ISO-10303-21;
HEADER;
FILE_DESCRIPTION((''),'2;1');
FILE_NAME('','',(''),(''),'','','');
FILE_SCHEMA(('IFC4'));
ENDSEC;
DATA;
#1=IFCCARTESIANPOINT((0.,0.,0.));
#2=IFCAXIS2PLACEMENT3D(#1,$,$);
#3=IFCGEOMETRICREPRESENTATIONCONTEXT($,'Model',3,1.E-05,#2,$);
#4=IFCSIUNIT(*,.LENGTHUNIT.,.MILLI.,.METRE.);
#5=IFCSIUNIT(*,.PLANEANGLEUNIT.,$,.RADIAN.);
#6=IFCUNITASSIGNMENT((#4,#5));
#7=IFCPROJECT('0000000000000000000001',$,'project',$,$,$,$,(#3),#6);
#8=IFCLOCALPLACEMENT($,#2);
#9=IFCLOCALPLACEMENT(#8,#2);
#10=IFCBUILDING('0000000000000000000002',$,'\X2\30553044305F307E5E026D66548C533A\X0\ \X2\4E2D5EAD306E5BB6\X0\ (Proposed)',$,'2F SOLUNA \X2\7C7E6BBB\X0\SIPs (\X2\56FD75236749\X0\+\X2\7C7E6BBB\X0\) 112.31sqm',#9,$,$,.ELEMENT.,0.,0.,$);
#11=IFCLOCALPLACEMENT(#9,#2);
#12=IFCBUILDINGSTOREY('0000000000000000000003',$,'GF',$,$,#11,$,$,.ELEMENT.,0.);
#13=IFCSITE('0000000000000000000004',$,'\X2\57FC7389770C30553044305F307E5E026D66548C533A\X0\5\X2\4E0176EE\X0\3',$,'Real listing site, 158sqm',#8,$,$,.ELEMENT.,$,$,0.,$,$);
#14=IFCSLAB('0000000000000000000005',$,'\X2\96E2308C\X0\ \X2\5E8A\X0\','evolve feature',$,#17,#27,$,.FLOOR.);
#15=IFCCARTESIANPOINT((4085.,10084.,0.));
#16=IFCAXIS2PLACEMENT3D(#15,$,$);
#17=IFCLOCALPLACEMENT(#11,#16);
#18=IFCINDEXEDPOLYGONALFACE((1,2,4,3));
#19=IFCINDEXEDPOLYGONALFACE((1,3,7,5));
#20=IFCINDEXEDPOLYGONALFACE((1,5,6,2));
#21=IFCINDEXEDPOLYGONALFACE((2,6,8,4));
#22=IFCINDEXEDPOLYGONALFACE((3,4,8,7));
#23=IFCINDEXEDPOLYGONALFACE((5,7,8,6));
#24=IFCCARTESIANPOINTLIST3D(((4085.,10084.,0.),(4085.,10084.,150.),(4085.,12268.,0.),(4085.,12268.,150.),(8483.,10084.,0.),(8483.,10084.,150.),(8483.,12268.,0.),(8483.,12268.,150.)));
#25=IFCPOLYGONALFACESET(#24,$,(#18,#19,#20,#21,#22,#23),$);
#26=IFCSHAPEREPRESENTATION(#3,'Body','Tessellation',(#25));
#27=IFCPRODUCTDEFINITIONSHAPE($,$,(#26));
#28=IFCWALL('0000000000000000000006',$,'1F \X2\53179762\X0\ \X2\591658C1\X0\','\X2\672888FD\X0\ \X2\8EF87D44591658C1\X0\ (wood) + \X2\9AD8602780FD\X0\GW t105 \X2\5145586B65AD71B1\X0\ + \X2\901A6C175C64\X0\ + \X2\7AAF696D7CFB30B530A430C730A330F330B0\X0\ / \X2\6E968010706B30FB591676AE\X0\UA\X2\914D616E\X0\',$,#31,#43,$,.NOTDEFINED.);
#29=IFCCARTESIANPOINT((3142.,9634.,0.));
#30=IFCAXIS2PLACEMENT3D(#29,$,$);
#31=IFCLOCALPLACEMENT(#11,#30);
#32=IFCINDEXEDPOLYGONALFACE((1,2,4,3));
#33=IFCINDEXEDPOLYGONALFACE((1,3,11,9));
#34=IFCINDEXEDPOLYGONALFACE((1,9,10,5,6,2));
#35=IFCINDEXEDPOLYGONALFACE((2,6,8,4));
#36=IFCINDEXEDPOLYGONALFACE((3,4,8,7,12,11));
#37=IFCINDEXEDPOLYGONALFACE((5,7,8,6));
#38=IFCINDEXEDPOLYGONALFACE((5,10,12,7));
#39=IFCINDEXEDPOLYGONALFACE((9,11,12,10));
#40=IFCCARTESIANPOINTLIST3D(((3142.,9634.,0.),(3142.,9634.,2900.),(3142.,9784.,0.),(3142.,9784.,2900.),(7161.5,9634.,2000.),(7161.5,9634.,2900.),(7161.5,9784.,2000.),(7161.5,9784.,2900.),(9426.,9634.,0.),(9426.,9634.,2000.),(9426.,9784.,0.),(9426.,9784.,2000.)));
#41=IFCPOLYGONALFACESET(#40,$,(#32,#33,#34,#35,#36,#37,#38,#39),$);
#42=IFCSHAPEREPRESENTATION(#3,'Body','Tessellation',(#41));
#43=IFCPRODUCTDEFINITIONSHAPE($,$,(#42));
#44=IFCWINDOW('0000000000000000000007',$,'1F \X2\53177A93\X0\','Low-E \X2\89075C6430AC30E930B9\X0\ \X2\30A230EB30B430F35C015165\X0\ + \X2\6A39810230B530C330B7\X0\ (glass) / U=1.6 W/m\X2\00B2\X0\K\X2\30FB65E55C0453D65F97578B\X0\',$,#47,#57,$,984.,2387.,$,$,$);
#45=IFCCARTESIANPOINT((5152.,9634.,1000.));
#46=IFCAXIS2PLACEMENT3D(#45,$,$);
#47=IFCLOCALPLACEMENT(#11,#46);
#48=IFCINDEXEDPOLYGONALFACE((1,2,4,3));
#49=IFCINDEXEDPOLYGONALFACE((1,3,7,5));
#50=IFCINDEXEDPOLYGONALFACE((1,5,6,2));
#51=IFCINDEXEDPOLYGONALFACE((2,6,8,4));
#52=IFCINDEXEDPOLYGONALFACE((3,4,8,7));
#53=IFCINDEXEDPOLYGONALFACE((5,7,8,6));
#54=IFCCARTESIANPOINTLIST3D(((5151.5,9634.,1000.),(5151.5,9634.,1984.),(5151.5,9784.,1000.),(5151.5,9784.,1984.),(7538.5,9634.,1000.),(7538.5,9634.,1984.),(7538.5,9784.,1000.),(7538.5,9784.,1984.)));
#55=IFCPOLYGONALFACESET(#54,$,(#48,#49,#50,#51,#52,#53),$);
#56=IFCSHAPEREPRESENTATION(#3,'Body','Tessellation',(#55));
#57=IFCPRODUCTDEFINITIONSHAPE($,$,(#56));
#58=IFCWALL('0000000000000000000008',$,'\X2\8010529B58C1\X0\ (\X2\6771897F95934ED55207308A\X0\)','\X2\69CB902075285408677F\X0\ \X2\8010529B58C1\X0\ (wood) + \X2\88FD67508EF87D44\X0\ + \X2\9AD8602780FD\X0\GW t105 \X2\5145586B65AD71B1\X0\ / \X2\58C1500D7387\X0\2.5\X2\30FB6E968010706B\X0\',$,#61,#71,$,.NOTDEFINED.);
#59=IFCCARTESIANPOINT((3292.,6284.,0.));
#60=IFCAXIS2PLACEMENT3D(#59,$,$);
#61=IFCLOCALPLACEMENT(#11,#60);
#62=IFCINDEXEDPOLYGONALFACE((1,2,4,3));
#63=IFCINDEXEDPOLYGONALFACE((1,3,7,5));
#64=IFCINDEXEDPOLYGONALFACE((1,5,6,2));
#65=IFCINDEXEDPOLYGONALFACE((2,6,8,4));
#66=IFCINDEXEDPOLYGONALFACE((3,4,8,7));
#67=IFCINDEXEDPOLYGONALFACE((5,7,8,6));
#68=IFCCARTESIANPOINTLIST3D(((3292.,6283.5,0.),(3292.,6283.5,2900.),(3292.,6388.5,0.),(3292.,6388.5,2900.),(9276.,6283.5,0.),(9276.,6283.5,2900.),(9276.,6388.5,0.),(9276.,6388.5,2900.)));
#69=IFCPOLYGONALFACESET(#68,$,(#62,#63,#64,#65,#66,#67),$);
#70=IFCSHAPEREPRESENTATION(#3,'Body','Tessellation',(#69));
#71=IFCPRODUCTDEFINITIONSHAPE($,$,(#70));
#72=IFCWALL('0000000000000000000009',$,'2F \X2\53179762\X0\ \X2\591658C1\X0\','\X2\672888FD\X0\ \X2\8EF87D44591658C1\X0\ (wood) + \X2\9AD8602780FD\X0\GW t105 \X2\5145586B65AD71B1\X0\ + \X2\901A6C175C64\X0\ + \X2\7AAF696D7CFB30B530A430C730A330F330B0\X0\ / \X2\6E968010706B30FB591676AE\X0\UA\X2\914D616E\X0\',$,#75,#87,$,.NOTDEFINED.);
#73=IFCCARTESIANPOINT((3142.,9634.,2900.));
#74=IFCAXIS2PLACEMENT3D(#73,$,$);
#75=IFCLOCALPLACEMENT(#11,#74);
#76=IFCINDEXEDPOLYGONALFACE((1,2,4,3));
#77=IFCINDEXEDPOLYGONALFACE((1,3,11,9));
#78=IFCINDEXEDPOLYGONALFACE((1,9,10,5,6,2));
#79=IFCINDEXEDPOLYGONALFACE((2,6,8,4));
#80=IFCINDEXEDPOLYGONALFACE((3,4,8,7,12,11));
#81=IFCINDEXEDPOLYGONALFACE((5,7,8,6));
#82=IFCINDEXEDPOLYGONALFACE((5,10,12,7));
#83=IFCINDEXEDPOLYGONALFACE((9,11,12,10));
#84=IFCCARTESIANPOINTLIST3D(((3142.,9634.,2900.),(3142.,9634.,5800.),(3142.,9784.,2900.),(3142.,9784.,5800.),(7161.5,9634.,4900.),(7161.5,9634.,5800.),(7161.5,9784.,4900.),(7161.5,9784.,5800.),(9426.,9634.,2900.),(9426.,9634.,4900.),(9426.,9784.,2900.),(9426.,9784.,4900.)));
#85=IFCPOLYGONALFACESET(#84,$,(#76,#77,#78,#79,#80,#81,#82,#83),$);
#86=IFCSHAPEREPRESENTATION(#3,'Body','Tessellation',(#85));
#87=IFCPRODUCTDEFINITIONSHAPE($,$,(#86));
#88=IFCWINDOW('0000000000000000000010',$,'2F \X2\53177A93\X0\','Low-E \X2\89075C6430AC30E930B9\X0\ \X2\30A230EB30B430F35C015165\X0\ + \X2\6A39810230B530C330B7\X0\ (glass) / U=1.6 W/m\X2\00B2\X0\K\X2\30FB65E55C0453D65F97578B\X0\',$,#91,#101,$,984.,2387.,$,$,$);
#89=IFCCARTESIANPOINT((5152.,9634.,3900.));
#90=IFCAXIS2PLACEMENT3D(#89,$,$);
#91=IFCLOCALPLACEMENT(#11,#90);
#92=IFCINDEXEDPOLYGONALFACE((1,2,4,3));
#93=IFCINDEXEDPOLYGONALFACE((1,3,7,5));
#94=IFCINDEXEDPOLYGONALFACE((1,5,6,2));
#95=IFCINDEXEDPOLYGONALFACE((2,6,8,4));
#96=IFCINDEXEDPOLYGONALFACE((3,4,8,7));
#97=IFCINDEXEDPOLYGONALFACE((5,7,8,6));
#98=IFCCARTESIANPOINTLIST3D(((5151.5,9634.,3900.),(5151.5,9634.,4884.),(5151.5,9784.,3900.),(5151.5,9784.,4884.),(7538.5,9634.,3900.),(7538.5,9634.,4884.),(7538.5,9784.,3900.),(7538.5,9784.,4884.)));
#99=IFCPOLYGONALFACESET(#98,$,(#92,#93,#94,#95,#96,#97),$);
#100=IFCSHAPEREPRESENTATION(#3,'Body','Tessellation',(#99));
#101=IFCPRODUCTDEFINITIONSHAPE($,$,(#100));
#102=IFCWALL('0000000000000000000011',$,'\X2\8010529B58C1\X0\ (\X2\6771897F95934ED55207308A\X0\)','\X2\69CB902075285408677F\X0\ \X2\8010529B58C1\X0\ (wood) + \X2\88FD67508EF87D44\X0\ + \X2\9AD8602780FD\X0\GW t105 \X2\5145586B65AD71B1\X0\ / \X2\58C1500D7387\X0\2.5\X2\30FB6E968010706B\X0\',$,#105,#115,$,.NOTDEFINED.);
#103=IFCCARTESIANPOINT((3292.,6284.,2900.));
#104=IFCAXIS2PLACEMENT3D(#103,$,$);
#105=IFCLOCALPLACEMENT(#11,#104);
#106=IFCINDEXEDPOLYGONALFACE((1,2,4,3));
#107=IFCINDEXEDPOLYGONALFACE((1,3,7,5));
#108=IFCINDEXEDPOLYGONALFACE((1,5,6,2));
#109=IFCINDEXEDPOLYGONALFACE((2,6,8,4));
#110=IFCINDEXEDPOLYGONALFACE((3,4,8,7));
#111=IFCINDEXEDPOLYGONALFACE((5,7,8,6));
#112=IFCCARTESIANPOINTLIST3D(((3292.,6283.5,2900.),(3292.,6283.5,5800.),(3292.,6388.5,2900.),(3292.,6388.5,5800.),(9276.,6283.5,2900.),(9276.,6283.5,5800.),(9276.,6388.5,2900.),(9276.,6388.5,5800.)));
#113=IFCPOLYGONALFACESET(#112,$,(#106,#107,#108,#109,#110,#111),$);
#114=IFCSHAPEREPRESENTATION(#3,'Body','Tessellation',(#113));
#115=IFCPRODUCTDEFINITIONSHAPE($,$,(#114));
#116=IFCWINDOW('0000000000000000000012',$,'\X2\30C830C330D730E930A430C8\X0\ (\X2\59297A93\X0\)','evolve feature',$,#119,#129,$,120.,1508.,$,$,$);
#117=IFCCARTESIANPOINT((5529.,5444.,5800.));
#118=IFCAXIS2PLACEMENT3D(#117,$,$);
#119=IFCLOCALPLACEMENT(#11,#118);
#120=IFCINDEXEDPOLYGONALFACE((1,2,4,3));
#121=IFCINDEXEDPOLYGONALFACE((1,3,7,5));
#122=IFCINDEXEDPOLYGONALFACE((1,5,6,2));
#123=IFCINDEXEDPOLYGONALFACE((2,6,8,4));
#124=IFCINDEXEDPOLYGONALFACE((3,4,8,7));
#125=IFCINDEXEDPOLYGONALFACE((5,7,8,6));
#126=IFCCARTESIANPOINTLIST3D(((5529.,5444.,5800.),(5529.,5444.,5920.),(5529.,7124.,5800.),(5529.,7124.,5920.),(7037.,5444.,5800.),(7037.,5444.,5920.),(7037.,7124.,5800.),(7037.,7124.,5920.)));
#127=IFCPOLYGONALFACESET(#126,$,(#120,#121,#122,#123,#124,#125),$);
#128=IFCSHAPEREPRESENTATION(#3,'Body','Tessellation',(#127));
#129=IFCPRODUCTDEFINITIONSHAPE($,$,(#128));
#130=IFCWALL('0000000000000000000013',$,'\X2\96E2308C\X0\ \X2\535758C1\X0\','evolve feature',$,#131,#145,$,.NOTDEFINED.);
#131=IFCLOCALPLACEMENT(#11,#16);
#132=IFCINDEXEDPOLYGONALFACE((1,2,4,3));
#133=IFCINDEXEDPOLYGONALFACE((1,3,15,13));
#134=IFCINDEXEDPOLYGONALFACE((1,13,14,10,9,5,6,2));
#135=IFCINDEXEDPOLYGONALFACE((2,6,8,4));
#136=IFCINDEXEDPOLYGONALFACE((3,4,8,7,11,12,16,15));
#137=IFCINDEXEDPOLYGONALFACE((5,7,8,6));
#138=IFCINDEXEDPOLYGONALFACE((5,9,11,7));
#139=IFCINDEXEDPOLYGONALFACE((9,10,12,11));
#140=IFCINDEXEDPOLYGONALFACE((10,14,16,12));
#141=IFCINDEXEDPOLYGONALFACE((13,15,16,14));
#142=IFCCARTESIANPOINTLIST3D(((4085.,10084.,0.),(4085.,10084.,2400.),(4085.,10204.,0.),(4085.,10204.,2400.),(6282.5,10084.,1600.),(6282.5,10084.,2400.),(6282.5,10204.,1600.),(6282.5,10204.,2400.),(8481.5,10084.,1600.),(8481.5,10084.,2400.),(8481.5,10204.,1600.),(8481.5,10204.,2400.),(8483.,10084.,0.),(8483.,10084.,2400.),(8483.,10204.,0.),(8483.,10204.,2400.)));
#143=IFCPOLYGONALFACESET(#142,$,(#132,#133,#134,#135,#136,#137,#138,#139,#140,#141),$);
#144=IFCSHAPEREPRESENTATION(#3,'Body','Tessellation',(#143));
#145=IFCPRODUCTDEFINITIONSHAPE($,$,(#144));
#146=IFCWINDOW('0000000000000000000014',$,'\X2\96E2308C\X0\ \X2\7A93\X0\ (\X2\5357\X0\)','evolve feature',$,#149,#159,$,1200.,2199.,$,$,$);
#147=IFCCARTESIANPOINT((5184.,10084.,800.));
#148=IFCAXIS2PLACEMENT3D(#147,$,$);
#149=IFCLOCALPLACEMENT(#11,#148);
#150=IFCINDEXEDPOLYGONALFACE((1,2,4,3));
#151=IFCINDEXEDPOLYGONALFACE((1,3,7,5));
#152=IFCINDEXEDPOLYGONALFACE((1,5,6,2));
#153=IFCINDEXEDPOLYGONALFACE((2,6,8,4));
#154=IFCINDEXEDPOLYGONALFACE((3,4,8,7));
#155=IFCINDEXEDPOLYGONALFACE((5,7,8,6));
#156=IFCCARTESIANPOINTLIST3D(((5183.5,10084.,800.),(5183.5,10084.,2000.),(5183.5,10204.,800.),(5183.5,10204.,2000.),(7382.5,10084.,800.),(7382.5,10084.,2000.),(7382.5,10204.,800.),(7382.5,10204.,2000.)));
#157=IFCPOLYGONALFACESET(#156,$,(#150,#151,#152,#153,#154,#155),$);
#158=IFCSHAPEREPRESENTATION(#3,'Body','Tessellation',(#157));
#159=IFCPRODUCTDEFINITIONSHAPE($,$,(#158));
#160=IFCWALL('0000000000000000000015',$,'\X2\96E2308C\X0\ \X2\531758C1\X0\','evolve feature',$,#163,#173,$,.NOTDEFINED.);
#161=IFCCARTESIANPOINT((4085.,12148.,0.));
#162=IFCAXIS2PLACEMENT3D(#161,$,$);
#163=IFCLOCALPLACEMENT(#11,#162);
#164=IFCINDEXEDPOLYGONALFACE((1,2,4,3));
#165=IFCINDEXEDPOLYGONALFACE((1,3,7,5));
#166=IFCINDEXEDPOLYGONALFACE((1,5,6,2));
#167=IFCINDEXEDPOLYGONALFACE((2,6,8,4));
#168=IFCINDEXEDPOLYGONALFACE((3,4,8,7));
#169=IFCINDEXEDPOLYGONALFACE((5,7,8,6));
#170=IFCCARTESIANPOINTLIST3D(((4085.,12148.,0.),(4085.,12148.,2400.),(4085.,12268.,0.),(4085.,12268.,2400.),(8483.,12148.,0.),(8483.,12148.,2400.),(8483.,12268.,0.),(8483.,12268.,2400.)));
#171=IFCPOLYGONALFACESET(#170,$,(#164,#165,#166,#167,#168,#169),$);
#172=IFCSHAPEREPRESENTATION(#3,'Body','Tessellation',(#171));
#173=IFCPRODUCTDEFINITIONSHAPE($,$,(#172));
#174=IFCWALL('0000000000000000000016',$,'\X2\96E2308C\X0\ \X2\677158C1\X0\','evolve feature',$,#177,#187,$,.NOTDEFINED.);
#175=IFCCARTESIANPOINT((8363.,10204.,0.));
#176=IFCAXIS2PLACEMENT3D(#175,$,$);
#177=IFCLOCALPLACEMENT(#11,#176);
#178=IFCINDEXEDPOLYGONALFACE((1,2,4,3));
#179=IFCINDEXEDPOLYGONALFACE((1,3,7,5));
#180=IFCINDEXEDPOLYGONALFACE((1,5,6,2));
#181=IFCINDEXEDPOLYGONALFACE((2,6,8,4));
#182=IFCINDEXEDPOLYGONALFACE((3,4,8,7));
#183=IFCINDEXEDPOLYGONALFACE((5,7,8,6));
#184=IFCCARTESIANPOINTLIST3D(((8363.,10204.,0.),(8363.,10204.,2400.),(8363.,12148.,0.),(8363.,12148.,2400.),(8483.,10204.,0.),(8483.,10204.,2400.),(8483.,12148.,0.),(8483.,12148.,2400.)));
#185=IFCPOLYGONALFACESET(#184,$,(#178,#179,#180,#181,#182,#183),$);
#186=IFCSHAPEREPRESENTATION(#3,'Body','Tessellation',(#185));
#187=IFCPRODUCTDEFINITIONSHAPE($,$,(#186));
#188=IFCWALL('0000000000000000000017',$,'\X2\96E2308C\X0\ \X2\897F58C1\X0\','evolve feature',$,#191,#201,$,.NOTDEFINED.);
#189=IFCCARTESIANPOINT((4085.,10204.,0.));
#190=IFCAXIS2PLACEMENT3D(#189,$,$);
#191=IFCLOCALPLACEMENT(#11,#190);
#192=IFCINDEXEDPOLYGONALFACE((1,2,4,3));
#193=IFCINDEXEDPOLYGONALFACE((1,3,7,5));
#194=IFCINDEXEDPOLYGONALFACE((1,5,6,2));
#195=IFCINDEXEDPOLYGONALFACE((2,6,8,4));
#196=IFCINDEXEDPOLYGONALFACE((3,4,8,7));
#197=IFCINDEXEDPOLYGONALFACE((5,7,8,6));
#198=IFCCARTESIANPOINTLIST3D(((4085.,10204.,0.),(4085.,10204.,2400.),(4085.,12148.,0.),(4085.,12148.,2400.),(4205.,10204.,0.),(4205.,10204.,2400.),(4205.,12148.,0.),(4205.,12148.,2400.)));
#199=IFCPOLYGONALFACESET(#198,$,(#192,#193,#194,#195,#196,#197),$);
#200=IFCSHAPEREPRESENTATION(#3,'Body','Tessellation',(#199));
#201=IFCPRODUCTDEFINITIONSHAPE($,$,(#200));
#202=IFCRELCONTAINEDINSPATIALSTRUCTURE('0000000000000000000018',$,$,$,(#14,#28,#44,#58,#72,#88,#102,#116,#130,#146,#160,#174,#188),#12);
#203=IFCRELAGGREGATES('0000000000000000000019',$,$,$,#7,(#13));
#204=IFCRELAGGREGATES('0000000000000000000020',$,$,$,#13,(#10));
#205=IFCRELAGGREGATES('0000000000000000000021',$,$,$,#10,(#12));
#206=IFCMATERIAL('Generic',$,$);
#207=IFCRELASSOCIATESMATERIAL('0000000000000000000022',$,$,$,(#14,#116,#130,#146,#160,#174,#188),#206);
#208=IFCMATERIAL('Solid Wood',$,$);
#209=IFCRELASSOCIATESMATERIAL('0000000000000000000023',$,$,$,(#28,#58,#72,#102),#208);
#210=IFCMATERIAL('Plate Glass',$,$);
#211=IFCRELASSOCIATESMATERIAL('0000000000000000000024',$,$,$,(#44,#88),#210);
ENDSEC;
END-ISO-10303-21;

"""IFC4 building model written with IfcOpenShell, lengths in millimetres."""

from ifc_helpers import new_model, si_unit, frame, frame_2d, origin, place, context, project, spatial, rectangle, extrude, material, element, fill, save


model = new_model("IFC4")

# Units and contexts
model_context = context("Model", 3, precision=1e-05, world=origin())
ifc_project = project(units=[si_unit("LENGTHUNIT", "METRE", prefix="MILLI"), si_unit("PLANEANGLEUNIT", "RADIAN")], contexts=[model_context])

# Site, building, storey
site_placement = place(None, origin())
site = spatial("IfcSite", under=ifc_project, at=site_placement, Name="埼玉県さいたま市浦和区5丁目3", ObjectType="Real listing site, 158sqm", CompositionType="ELEMENT", RefElevation=0.0)
building_placement = place(site_placement, origin())
building = spatial("IfcBuilding", under=site, at=building_placement, Name="さいたま市浦和区 中庭の家 (Proposed)", ObjectType="2F SOLUNA 籾殻SIPs (国産杉+籾殻) 112.31sqm", CompositionType="ELEMENT", ElevationOfRefHeight=0.0, ElevationOfTerrain=0.0)
storey_placement = place(building_placement, origin())
storey = spatial("IfcBuildingStorey", under=building, at=storey_placement, Name="GF", CompositionType="ELEMENT", Elevation=0.0)

# Slab
ifc_material_1 = material(Name="Generic")
slab_placement = place(storey_placement, frame((4085.0, 10084.0, 0.0)))
element("IfcSlab", 1, at=slab_placement, inside=storey, material=ifc_material_1, Name="離れ 床", Description="evolve feature", PredefinedType="FLOOR", context=model_context, shape_type="SweptSolid", body=[
    extrude(rectangle(XDim=4398.0, YDim=2184.0, at=frame_2d((2199.0, 1092.0))), frame((4085.0, 10084.0, 0.0)), (0.0, 0.0, 1.0), 150.0),
])

# Wall, opening, window
ifc_material_2 = material(Name="Solid Wood")
wall_1_placement = place(storey_placement, frame((3142.0, 9634.0, 0.0)))
wall_1 = element("IfcWall", 2, at=wall_1_placement, inside=storey, material=ifc_material_2, Name="1F 北面 外壁", Description="木製 軸組外壁 (wood) + 高性能GW t105 充填断熱 + 通気層 + 窯業系サイディング / 準耐火・外皮UA配慮", PredefinedType="NOTDEFINED", context=model_context, shape_type="SweptSolid", body=[
    extrude(rectangle(XDim=6284.0, YDim=150.0, at=frame_2d((3142.0, 75.0))), frame((3142.0, 9634.0, 0.0)), (0.0, 0.0, 1.0), 2900.0),
])
opening_1_placement = place(storey_placement, frame((5152.0, 9634.0, 1000.0)))
opening_1 = element("IfcOpeningElement", 3, at=opening_1_placement, cuts=wall_1, PredefinedType="NOTDEFINED", context=model_context, shape_type="SweptSolid", body=[
    extrude(rectangle(XDim=2387.0, YDim=150.0, at=frame_2d((1193.0, 75.0))), frame((5152.0, 9634.0, 1000.0)), (0.0, 0.0, 1.0), 984.0),
])
ifc_material_3 = material(Name="Plate Glass")
window_1_placement = place(storey_placement, frame((5152.0, 9634.0, 1000.0)))
window_1 = element("IfcWindow", 4, at=window_1_placement, inside=storey, material=ifc_material_3, Name="1F 北窓", Description="Low-E 複層ガラス アルゴン封入 + 樹脂サッシ (glass) / U=1.6 W/m²K・日射取得型", OverallHeight=984.0, OverallWidth=2387.0, context=model_context, shape_type="SweptSolid", body=[
    extrude(rectangle(XDim=2387.0, YDim=150.0, at=frame_2d((1193.0, 75.0))), frame((5152.0, 9634.0, 1000.0)), (0.0, 0.0, 1.0), 984.0),
])
fill(opening_1, window_1)

# Wall
wall_2_placement = place(storey_placement, frame((3292.0, 6284.0, 0.0)))
element("IfcWall", 5, at=wall_2_placement, inside=storey, material=ifc_material_2, Name="耐力壁 (東西間仕切り)", Description="構造用合板 耐力壁 (wood) + 製材軸組 + 高性能GW t105 充填断熱 / 壁倍率2.5・準耐火", PredefinedType="NOTDEFINED", context=model_context, shape_type="SweptSolid", body=[
    extrude(rectangle(XDim=5984.0, YDim=105.0, at=frame_2d((2992.0, 52.0))), frame((3292.0, 6284.0, 0.0)), (0.0, 0.0, 1.0), 2900.0),
])

# Wall, opening, window
wall_3_placement = place(storey_placement, frame((3142.0, 9634.0, 2900.0)))
wall_3 = element("IfcWall", 6, at=wall_3_placement, inside=storey, material=ifc_material_2, Name="2F 北面 外壁", Description="木製 軸組外壁 (wood) + 高性能GW t105 充填断熱 + 通気層 + 窯業系サイディング / 準耐火・外皮UA配慮", PredefinedType="NOTDEFINED", context=model_context, shape_type="SweptSolid", body=[
    extrude(rectangle(XDim=6284.0, YDim=150.0, at=frame_2d((3142.0, 75.0))), frame((3142.0, 9634.0, 2900.0)), (0.0, 0.0, 1.0), 2900.0),
])
opening_2_placement = place(storey_placement, frame((5152.0, 9634.0, 3900.0)))
opening_2 = element("IfcOpeningElement", 7, at=opening_2_placement, cuts=wall_3, PredefinedType="NOTDEFINED", context=model_context, shape_type="SweptSolid", body=[
    extrude(rectangle(XDim=2387.0, YDim=150.0, at=frame_2d((1193.0, 75.0))), frame((5152.0, 9634.0, 3900.0)), (0.0, 0.0, 1.0), 984.0),
])
window_2_placement = place(storey_placement, frame((5152.0, 9634.0, 3900.0)))
window_2 = element("IfcWindow", 8, at=window_2_placement, inside=storey, material=ifc_material_3, Name="2F 北窓", Description="Low-E 複層ガラス アルゴン封入 + 樹脂サッシ (glass) / U=1.6 W/m²K・日射取得型", OverallHeight=984.0, OverallWidth=2387.0, context=model_context, shape_type="SweptSolid", body=[
    extrude(rectangle(XDim=2387.0, YDim=150.0, at=frame_2d((1193.0, 75.0))), frame((5152.0, 9634.0, 3900.0)), (0.0, 0.0, 1.0), 984.0),
])
fill(opening_2, window_2)

# Wall
wall_4_placement = place(storey_placement, frame((3292.0, 6284.0, 2900.0)))
element("IfcWall", 9, at=wall_4_placement, inside=storey, material=ifc_material_2, Name="耐力壁 (東西間仕切り)", Description="構造用合板 耐力壁 (wood) + 製材軸組 + 高性能GW t105 充填断熱 / 壁倍率2.5・準耐火", PredefinedType="NOTDEFINED", context=model_context, shape_type="SweptSolid", body=[
    extrude(rectangle(XDim=5984.0, YDim=105.0, at=frame_2d((2992.0, 52.0))), frame((3292.0, 6284.0, 2900.0)), (0.0, 0.0, 1.0), 2900.0),
])

# Window
window_3_placement = place(storey_placement, frame((5529.0, 5444.0, 5800.0)))
element("IfcWindow", 10, at=window_3_placement, inside=storey, material=ifc_material_1, Name="トップライト (天窓)", Description="evolve feature", OverallHeight=120.0, OverallWidth=1508.0, context=model_context, shape_type="SweptSolid", body=[
    extrude(rectangle(XDim=1508.0, YDim=1680.0, at=frame_2d((754.0, 840.0))), frame((5529.0, 5444.0, 5800.0)), (0.0, 0.0, 1.0), 120.0),
])

# Wall, opening, window
wall_5_placement = place(storey_placement, frame((4085.0, 10084.0, 0.0)))
wall_5 = element("IfcWall", 11, at=wall_5_placement, inside=storey, material=ifc_material_1, Name="離れ 南壁", Description="evolve feature", PredefinedType="NOTDEFINED", context=model_context, shape_type="SweptSolid", body=[
    extrude(rectangle(XDim=4398.0, YDim=120.0, at=frame_2d((2199.0, 60.0))), frame((4085.0, 10084.0, 0.0)), (0.0, 0.0, 1.0), 2400.0),
])
opening_3_placement = place(storey_placement, frame((5184.0, 10084.0, 800.0)))
opening_3 = element("IfcOpeningElement", 12, at=opening_3_placement, cuts=wall_5, PredefinedType="NOTDEFINED", context=model_context, shape_type="SweptSolid", body=[
    extrude(rectangle(XDim=2199.0, YDim=120.0, at=frame_2d((1099.0, 60.0))), frame((5184.0, 10084.0, 800.0)), (0.0, 0.0, 1.0), 1200.0),
])
window_4_placement = place(storey_placement, frame((5184.0, 10084.0, 800.0)))
window_4 = element("IfcWindow", 13, at=window_4_placement, inside=storey, material=ifc_material_1, Name="離れ 窓 (南)", Description="evolve feature", OverallHeight=1200.0, OverallWidth=2199.0, context=model_context, shape_type="SweptSolid", body=[
    extrude(rectangle(XDim=2199.0, YDim=120.0, at=frame_2d((1099.0, 60.0))), frame((5184.0, 10084.0, 800.0)), (0.0, 0.0, 1.0), 1200.0),
])
fill(opening_3, window_4)

# Walls
wall_6_placement = place(storey_placement, frame((4085.0, 12148.0, 0.0)))
element("IfcWall", 14, at=wall_6_placement, inside=storey, material=ifc_material_1, Name="離れ 北壁", Description="evolve feature", PredefinedType="NOTDEFINED", context=model_context, shape_type="SweptSolid", body=[
    extrude(rectangle(XDim=4398.0, YDim=120.0, at=frame_2d((2199.0, 60.0))), frame((4085.0, 12148.0, 0.0)), (0.0, 0.0, 1.0), 2400.0),
])
wall_7_placement = place(storey_placement, frame((8363.0, 10204.0, 0.0)))
element("IfcWall", 15, at=wall_7_placement, inside=storey, material=ifc_material_1, Name="離れ 東壁", Description="evolve feature", PredefinedType="NOTDEFINED", context=model_context, shape_type="SweptSolid", body=[
    extrude(rectangle(XDim=120.0, YDim=1944.0, at=frame_2d((60.0, 972.0))), frame((8363.0, 10204.0, 0.0)), (0.0, 0.0, 1.0), 2400.0),
])
wall_8_placement = place(storey_placement, frame((4085.0, 10204.0, 0.0)))
element("IfcWall", 16, at=wall_8_placement, inside=storey, material=ifc_material_1, Name="離れ 西壁", Description="evolve feature", PredefinedType="NOTDEFINED", context=model_context, shape_type="SweptSolid", body=[
    extrude(rectangle(XDim=120.0, YDim=1944.0, at=frame_2d((60.0, 972.0))), frame((4085.0, 10204.0, 0.0)), (0.0, 0.0, 1.0), 2400.0),
])

save(model, "model.ifc")
